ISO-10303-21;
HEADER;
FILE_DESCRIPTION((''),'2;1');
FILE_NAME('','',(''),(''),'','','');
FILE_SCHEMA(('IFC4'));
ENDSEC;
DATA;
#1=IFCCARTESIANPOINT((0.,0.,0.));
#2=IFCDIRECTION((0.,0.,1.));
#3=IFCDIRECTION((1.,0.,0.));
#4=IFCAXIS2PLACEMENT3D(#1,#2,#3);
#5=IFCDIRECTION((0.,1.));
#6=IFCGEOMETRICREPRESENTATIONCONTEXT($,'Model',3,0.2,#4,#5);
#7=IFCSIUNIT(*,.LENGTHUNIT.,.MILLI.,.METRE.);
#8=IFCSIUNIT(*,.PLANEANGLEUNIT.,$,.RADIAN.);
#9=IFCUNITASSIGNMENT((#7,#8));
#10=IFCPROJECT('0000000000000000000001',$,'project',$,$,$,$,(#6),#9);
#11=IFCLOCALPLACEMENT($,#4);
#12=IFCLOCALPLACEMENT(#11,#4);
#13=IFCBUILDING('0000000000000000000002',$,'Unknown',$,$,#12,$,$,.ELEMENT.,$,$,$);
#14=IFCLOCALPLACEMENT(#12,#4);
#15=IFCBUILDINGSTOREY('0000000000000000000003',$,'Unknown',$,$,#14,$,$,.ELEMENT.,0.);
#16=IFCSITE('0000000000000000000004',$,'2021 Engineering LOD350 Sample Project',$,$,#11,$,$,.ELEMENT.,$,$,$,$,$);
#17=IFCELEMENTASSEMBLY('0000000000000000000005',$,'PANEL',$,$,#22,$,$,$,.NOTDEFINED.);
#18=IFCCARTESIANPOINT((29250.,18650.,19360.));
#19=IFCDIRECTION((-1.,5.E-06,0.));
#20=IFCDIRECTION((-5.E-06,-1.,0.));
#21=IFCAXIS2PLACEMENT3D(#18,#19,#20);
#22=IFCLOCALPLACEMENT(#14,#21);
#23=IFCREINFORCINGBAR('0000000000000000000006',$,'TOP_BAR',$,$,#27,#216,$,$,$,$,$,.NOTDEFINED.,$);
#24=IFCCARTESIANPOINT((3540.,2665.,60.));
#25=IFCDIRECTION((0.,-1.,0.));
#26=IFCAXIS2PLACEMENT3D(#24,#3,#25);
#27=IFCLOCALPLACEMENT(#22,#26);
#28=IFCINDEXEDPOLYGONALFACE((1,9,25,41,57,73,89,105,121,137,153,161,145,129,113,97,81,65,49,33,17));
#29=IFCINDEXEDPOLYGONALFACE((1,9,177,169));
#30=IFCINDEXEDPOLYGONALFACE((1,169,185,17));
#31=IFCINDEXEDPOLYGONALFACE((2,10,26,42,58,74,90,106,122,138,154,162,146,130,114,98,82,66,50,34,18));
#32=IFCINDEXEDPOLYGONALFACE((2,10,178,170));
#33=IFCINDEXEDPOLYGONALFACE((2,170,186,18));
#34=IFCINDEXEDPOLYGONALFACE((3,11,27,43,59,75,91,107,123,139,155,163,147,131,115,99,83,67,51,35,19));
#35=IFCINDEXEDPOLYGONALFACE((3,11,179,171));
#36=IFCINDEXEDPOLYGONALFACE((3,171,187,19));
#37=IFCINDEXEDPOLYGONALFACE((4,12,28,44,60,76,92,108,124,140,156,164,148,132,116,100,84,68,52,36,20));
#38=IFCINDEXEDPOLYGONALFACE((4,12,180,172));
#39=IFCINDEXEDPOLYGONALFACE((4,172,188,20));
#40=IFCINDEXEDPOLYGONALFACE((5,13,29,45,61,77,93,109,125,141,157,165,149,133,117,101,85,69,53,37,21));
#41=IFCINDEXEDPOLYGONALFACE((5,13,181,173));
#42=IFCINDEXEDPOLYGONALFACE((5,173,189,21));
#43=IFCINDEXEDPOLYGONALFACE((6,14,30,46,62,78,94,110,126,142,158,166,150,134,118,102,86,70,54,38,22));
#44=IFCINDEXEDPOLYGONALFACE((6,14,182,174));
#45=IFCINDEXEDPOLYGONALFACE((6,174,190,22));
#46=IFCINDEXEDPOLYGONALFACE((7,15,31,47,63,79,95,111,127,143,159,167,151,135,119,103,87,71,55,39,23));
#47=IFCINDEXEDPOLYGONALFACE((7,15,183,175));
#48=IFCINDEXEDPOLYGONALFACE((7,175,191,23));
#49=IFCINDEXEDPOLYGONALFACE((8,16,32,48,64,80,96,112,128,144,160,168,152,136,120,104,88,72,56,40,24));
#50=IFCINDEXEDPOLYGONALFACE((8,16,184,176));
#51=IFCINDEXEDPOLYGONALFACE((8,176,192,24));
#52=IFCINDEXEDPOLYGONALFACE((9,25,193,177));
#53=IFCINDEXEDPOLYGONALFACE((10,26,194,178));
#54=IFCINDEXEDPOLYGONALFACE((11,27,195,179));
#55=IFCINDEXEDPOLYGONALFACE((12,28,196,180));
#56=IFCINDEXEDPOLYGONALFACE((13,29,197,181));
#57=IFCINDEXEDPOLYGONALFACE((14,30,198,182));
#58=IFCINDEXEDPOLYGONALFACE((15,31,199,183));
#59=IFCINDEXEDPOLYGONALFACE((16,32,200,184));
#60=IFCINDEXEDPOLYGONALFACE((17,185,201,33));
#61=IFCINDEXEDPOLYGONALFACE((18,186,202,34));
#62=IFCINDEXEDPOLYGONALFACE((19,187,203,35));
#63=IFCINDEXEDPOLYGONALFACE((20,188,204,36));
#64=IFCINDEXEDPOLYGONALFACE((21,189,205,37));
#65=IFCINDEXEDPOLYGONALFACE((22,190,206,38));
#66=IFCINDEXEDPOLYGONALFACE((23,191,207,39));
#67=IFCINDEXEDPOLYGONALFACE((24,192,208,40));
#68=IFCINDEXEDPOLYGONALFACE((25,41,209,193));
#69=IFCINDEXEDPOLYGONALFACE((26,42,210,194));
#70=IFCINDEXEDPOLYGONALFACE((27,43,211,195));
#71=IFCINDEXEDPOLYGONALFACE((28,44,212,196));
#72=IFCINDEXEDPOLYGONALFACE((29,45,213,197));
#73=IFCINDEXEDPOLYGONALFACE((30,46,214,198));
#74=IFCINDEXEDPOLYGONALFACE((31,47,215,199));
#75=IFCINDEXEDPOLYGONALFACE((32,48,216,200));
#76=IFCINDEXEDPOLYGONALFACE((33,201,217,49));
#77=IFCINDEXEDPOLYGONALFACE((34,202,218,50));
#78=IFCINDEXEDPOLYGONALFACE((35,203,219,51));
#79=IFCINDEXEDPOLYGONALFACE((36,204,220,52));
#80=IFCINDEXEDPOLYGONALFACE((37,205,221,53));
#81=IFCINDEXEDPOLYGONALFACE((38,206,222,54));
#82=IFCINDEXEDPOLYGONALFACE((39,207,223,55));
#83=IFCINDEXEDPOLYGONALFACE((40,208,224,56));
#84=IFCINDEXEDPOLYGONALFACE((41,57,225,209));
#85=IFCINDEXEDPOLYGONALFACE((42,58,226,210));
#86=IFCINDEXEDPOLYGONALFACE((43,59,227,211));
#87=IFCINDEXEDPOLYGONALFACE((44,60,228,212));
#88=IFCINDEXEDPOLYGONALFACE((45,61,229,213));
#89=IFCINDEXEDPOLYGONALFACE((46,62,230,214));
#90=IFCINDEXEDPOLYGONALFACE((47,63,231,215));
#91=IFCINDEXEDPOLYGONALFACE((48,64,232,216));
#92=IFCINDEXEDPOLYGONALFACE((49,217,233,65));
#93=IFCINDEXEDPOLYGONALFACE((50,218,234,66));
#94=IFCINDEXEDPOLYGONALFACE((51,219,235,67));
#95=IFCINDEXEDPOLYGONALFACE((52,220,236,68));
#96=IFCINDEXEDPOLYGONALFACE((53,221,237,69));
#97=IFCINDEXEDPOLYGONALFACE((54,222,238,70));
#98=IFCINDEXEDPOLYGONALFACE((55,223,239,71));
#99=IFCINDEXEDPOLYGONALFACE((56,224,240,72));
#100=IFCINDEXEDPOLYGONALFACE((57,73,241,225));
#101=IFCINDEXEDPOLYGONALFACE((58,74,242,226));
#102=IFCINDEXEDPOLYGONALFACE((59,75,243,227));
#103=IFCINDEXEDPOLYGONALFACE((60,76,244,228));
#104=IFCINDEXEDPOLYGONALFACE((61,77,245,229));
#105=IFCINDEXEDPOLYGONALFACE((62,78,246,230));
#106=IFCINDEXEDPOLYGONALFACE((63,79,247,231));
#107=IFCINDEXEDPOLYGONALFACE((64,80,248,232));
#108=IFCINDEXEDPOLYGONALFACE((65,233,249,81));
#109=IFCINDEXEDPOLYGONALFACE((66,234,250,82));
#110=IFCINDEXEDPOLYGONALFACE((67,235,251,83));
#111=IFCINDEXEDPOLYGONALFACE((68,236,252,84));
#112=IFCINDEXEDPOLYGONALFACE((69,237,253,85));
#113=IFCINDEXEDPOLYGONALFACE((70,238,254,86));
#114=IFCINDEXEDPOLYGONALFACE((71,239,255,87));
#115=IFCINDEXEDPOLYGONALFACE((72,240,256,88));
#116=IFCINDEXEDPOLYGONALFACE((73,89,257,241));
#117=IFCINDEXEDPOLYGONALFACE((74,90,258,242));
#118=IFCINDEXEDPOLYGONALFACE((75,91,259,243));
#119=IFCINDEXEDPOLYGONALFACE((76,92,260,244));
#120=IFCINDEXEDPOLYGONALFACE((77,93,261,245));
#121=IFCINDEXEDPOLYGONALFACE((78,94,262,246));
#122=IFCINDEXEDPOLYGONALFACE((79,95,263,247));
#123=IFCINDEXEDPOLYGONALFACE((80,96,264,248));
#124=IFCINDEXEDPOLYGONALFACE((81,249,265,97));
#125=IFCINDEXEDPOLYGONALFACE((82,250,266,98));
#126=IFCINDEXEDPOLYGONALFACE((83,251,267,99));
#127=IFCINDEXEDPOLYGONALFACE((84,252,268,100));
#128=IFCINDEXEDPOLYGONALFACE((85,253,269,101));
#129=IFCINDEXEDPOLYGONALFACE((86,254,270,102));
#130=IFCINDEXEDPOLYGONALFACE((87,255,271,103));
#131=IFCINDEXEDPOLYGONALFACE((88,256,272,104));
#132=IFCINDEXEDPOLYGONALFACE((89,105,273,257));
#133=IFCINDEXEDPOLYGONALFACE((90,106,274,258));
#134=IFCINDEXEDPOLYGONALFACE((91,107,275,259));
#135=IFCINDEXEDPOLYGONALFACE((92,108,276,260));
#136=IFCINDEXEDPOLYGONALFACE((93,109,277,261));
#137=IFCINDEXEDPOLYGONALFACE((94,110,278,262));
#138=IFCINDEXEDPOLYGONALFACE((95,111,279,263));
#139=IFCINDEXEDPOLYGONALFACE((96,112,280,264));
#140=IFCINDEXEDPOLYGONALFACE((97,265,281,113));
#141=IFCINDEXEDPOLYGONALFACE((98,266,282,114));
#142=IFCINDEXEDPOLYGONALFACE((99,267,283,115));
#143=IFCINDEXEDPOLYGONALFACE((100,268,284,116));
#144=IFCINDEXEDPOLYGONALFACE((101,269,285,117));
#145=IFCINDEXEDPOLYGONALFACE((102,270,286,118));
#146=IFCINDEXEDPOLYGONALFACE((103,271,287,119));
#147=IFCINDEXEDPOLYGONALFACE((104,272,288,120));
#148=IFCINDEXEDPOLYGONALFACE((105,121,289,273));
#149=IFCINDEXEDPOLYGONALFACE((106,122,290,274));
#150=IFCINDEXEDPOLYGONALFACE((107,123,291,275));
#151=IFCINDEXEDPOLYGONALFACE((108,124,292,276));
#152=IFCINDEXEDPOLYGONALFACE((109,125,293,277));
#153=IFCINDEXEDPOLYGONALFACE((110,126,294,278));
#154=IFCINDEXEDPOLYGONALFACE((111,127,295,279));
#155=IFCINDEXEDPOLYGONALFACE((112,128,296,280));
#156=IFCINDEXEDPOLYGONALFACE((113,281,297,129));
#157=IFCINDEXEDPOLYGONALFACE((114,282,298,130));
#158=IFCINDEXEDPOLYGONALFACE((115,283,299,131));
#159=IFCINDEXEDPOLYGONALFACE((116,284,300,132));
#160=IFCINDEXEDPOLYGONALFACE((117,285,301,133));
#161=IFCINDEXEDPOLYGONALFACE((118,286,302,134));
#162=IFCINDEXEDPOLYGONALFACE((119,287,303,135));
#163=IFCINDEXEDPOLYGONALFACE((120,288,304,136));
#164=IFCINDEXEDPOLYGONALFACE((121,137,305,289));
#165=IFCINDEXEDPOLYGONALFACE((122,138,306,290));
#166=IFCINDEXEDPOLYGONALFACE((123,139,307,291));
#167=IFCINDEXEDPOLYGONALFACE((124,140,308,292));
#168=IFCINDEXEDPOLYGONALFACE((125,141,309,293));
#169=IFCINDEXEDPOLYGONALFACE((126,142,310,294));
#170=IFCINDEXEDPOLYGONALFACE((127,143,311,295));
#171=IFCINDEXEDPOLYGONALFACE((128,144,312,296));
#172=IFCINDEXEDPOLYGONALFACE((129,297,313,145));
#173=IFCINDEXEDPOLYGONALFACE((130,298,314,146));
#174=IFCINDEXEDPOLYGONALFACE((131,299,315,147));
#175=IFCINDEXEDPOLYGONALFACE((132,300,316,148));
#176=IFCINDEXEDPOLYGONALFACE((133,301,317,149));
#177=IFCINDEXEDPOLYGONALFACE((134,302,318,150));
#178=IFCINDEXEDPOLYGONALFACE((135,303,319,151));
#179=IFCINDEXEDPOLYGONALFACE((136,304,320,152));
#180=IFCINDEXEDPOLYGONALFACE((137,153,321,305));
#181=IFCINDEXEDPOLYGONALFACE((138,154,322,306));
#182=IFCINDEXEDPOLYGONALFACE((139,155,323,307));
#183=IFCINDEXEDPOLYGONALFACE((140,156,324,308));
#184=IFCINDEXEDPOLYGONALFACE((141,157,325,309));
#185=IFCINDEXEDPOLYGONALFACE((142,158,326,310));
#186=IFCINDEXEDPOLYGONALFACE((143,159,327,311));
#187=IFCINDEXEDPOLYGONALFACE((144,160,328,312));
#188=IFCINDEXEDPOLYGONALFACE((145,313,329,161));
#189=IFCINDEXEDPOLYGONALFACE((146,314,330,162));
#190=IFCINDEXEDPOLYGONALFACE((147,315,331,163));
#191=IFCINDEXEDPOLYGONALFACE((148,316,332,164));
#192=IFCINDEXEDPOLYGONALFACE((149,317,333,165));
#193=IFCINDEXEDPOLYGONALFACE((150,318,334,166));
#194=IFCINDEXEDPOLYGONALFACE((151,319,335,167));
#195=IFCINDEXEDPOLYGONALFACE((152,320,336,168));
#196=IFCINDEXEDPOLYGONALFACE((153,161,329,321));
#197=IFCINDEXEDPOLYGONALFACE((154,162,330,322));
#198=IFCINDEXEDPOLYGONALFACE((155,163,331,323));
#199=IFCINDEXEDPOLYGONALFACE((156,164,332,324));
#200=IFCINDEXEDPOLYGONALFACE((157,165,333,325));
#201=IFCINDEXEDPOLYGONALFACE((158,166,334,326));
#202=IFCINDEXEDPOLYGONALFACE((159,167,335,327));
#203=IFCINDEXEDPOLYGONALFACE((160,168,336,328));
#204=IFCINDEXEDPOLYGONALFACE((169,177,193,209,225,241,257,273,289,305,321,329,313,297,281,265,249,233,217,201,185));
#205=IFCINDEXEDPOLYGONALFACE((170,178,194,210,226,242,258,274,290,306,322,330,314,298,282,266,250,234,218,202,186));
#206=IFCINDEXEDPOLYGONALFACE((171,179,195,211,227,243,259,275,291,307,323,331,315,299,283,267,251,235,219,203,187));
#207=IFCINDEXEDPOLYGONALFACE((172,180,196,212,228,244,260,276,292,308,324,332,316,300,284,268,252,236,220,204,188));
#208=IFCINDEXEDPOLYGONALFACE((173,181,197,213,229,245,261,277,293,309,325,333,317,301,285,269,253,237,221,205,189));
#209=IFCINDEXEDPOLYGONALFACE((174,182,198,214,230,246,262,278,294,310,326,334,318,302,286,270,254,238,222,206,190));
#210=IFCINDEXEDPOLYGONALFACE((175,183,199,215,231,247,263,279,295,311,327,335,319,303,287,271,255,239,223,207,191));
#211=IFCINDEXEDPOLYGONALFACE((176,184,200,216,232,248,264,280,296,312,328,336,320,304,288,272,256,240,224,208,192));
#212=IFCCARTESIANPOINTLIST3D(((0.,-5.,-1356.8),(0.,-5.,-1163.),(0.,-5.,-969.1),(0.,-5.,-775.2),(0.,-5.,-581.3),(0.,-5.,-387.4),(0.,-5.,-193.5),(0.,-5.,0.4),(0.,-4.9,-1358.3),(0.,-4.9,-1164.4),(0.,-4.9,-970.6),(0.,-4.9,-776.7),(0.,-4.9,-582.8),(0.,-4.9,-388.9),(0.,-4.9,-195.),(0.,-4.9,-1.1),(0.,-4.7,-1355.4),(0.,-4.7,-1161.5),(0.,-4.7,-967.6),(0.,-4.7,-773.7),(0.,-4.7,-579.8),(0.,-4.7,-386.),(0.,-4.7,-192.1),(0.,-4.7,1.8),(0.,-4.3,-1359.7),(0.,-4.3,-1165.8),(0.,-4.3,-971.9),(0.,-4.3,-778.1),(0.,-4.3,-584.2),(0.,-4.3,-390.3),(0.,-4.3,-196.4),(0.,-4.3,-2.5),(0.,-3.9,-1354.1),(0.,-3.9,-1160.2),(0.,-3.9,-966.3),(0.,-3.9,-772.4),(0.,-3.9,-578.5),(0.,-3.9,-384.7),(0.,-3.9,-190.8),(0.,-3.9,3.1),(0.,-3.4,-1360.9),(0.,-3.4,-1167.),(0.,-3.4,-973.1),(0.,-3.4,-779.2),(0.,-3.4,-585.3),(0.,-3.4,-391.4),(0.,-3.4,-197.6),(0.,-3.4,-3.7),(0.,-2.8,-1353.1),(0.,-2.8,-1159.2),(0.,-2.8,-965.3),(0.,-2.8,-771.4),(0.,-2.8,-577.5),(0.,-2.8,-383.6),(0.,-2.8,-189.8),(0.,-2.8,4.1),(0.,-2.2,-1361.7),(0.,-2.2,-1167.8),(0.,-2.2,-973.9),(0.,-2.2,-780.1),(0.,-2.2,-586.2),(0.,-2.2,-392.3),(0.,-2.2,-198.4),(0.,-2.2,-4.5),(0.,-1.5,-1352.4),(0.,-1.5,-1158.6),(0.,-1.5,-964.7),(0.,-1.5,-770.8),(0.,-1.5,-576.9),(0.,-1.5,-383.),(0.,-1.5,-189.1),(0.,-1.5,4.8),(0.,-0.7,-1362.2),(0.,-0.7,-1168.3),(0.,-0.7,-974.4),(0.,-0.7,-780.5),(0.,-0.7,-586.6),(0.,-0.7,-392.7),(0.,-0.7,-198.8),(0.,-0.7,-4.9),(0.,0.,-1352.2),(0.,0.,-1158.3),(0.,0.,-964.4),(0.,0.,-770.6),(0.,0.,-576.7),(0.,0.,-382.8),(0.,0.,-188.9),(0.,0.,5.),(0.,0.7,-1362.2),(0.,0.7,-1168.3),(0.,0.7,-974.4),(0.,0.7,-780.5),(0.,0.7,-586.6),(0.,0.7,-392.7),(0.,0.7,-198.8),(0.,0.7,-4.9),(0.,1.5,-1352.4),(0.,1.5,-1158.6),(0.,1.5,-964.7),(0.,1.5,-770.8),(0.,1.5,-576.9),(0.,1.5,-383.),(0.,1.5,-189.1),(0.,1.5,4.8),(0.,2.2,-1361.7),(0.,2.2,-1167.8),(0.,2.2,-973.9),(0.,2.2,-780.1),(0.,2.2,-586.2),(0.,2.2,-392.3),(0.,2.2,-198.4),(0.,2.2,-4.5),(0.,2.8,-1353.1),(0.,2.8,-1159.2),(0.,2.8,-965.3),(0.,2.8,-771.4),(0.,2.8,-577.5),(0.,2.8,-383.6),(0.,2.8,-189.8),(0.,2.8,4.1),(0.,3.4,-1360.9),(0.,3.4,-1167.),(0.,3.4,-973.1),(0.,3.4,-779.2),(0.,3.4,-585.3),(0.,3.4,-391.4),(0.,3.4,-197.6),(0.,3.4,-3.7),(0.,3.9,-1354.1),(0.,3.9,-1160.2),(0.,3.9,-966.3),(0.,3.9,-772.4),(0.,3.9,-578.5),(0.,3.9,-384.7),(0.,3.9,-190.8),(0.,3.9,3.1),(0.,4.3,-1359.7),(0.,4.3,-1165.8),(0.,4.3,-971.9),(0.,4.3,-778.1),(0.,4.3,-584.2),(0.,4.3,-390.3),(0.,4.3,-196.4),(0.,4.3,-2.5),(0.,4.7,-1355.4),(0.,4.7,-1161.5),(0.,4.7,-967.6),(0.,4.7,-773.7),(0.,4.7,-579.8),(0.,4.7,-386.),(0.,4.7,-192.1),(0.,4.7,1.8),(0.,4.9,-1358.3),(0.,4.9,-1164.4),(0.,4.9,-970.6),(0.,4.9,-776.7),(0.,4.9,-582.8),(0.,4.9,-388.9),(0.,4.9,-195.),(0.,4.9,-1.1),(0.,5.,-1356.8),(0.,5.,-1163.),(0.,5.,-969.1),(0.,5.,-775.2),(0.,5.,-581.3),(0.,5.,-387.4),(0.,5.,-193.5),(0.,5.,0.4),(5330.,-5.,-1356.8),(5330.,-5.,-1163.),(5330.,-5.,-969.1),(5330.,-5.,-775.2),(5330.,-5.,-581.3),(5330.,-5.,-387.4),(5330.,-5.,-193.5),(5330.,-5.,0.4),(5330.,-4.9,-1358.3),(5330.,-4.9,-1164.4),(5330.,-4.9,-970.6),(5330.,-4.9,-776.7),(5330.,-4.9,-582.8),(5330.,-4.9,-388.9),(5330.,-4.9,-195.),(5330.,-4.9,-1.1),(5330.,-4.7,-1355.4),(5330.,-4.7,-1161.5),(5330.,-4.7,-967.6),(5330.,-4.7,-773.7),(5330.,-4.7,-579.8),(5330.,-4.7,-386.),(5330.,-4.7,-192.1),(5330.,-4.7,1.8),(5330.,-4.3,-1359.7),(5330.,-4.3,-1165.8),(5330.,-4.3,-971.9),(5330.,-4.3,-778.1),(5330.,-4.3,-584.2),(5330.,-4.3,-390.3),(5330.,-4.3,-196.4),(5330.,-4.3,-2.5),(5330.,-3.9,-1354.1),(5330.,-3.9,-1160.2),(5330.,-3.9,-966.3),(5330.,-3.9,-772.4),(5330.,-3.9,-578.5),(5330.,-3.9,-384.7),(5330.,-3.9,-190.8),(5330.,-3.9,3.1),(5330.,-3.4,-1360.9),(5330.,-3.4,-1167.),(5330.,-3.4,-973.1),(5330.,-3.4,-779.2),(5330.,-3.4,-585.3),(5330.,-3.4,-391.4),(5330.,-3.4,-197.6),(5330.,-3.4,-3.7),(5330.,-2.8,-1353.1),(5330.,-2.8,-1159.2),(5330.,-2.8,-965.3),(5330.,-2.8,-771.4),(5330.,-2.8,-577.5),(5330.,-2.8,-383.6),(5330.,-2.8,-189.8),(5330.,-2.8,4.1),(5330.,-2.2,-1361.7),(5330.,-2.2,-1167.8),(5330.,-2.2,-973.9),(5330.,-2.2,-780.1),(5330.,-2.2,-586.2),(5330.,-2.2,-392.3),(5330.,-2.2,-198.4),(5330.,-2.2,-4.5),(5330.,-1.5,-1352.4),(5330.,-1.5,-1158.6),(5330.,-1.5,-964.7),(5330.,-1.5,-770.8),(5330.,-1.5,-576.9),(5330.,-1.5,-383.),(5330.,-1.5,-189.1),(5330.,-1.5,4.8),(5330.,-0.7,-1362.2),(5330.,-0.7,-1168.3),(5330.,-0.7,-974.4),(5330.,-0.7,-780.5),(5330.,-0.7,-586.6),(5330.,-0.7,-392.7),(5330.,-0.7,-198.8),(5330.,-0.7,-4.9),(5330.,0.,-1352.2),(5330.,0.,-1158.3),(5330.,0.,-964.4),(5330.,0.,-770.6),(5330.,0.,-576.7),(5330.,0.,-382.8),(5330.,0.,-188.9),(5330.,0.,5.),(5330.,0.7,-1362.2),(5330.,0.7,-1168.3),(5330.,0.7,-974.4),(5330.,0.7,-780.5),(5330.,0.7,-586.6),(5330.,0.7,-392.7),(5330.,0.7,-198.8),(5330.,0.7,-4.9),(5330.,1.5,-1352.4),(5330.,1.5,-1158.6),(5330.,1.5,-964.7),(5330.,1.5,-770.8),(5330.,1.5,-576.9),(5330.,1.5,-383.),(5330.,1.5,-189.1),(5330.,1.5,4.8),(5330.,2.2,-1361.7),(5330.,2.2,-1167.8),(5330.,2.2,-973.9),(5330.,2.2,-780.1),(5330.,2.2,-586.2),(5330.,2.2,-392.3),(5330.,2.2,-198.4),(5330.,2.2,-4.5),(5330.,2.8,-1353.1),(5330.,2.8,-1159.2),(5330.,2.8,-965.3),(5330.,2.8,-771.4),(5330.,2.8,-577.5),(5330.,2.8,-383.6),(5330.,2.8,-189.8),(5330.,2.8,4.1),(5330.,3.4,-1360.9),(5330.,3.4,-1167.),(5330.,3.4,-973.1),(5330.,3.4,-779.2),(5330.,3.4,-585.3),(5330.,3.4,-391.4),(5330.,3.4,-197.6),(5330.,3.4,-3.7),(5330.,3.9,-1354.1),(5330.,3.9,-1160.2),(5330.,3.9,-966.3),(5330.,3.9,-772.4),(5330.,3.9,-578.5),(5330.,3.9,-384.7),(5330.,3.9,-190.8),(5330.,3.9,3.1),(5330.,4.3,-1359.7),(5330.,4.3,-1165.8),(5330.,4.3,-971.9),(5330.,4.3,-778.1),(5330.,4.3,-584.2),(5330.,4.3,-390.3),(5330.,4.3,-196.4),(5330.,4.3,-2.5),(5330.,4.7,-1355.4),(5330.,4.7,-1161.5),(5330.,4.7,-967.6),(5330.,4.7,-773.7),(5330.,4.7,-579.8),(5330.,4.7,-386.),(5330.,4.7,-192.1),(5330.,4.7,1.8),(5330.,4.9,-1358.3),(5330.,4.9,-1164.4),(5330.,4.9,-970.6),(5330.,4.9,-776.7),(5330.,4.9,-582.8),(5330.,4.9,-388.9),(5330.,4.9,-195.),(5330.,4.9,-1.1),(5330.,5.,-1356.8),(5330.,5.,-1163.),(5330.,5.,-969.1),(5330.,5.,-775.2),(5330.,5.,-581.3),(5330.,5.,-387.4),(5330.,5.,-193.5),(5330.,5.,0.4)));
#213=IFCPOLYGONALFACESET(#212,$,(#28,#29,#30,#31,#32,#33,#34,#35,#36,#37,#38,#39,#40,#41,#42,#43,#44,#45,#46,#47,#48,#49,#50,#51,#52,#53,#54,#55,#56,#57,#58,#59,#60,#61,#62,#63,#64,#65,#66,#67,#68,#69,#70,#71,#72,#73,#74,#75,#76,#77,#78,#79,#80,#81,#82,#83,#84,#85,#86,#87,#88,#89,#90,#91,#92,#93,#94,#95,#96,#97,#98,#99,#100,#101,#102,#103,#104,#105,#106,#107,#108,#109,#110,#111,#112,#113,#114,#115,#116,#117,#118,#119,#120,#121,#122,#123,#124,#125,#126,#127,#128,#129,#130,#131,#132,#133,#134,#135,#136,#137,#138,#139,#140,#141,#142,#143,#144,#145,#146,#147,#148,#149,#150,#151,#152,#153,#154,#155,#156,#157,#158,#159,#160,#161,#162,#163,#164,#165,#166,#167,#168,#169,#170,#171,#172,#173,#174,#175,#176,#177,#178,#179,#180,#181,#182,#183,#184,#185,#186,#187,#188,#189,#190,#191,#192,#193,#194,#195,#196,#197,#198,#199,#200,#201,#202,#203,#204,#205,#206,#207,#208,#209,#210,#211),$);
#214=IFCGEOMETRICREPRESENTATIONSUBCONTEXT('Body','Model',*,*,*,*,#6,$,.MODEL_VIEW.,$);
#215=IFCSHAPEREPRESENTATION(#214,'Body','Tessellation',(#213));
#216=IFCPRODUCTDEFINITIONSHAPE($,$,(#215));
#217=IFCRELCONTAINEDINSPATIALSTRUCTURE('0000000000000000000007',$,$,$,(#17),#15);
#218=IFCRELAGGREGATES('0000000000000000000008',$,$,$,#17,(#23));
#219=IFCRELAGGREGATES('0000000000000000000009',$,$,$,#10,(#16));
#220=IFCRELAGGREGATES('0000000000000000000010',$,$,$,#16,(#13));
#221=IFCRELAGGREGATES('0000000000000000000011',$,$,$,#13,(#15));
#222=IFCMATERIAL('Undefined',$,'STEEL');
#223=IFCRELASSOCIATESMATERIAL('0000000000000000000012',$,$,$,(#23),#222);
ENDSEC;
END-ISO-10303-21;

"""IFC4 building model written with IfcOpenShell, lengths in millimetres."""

from ifc_helpers import new_model, entity, si_unit, direction, frame, origin_with_axes, place, context, subcontext, project, spatial, source, transform, mapped, material, element, aggregate, save


model = new_model("IFC4")

# Units and contexts
model_context = context("Model", 3, precision=0.2, world=origin_with_axes(), true_north=direction((0.0, 1.0)))
body_context = subcontext(model_context, "Body", "Model", "MODEL_VIEW")
ifc_project = project(units=[si_unit("LENGTHUNIT", "METRE", prefix="MILLI"), si_unit("PLANEANGLEUNIT", "RADIAN")], contexts=[model_context])

# Site, building, storey
site_placement = place(None, origin_with_axes())
site = spatial("IfcSite", under=ifc_project, at=site_placement, Name="2021 Engineering LOD350 Sample Project", CompositionType="ELEMENT")
building_placement = place(site_placement, origin_with_axes())
building = spatial("IfcBuilding", under=site, at=building_placement, Name="Unknown", CompositionType="ELEMENT")
storey_placement = place(building_placement, origin_with_axes())
storey = spatial("IfcBuildingStorey", under=building, at=storey_placement, Name="Unknown", CompositionType="ELEMENT", Elevation=0.0)

# Shared definitions
ifc_material_1 = material(Name="Undefined", Category="STEEL")

# Element assembly, reinforcing bar
assembly_1_placement = place(storey_placement, frame((29250.0, 18650.0, 19360.0), z_axis=(-1.0, 0.000005, 0.0), x_axis=(-0.000005, -1.0, 0.0)))
assembly_1 = element("IfcElementAssembly", 1, at=assembly_1_placement, inside=storey, Name="PANEL", PredefinedType="NOTDEFINED")
shared_shape_1 = source(origin_with_axes(), body_context, "Body", "AdvancedSweptSolid", [
    entity("IfcSweptDiskSolid", entity("IfcIndexedPolyCurve", entity("IfcCartesianPointList3D", [[0.0, 0.0, 0.0], [5330.0, 0.0, 0.0]]), [entity("IfcLineIndex", [1, 2])]), 5.0),
])
reinforcing_bar_1_placement = place(assembly_1_placement, frame((3540.0, 2665.0, 60.0), z_axis=(1.0, 0.0, 0.0), x_axis=(0.0, -1.0, 0.0)))
reinforcing_bar_1 = element("IfcReinforcingBar", 2, at=reinforcing_bar_1_placement, material=ifc_material_1, Name="TOP_BAR", PredefinedType="NOTDEFINED", context=body_context, shape_type="MappedRepresentation", body=[
    mapped(shared_shape_1, transform((0.0, 0.0, 0.0))),
    mapped(shared_shape_1, transform((0.0, 0.0, -193.9))),
    mapped(shared_shape_1, transform((0.0, 0.0, -387.8))),
    mapped(shared_shape_1, transform((0.0, 0.0, -581.7))),
    mapped(shared_shape_1, transform((0.0, 0.0, -775.6))),
    mapped(shared_shape_1, transform((0.0, 0.0, -969.4))),
    mapped(shared_shape_1, transform((0.0, 0.0, -1163.3))),
    mapped(shared_shape_1, transform((0.0, 0.0, -1357.2))),
])
aggregate(assembly_1, [reinforcing_bar_1])

save(model, "model.ifc")
